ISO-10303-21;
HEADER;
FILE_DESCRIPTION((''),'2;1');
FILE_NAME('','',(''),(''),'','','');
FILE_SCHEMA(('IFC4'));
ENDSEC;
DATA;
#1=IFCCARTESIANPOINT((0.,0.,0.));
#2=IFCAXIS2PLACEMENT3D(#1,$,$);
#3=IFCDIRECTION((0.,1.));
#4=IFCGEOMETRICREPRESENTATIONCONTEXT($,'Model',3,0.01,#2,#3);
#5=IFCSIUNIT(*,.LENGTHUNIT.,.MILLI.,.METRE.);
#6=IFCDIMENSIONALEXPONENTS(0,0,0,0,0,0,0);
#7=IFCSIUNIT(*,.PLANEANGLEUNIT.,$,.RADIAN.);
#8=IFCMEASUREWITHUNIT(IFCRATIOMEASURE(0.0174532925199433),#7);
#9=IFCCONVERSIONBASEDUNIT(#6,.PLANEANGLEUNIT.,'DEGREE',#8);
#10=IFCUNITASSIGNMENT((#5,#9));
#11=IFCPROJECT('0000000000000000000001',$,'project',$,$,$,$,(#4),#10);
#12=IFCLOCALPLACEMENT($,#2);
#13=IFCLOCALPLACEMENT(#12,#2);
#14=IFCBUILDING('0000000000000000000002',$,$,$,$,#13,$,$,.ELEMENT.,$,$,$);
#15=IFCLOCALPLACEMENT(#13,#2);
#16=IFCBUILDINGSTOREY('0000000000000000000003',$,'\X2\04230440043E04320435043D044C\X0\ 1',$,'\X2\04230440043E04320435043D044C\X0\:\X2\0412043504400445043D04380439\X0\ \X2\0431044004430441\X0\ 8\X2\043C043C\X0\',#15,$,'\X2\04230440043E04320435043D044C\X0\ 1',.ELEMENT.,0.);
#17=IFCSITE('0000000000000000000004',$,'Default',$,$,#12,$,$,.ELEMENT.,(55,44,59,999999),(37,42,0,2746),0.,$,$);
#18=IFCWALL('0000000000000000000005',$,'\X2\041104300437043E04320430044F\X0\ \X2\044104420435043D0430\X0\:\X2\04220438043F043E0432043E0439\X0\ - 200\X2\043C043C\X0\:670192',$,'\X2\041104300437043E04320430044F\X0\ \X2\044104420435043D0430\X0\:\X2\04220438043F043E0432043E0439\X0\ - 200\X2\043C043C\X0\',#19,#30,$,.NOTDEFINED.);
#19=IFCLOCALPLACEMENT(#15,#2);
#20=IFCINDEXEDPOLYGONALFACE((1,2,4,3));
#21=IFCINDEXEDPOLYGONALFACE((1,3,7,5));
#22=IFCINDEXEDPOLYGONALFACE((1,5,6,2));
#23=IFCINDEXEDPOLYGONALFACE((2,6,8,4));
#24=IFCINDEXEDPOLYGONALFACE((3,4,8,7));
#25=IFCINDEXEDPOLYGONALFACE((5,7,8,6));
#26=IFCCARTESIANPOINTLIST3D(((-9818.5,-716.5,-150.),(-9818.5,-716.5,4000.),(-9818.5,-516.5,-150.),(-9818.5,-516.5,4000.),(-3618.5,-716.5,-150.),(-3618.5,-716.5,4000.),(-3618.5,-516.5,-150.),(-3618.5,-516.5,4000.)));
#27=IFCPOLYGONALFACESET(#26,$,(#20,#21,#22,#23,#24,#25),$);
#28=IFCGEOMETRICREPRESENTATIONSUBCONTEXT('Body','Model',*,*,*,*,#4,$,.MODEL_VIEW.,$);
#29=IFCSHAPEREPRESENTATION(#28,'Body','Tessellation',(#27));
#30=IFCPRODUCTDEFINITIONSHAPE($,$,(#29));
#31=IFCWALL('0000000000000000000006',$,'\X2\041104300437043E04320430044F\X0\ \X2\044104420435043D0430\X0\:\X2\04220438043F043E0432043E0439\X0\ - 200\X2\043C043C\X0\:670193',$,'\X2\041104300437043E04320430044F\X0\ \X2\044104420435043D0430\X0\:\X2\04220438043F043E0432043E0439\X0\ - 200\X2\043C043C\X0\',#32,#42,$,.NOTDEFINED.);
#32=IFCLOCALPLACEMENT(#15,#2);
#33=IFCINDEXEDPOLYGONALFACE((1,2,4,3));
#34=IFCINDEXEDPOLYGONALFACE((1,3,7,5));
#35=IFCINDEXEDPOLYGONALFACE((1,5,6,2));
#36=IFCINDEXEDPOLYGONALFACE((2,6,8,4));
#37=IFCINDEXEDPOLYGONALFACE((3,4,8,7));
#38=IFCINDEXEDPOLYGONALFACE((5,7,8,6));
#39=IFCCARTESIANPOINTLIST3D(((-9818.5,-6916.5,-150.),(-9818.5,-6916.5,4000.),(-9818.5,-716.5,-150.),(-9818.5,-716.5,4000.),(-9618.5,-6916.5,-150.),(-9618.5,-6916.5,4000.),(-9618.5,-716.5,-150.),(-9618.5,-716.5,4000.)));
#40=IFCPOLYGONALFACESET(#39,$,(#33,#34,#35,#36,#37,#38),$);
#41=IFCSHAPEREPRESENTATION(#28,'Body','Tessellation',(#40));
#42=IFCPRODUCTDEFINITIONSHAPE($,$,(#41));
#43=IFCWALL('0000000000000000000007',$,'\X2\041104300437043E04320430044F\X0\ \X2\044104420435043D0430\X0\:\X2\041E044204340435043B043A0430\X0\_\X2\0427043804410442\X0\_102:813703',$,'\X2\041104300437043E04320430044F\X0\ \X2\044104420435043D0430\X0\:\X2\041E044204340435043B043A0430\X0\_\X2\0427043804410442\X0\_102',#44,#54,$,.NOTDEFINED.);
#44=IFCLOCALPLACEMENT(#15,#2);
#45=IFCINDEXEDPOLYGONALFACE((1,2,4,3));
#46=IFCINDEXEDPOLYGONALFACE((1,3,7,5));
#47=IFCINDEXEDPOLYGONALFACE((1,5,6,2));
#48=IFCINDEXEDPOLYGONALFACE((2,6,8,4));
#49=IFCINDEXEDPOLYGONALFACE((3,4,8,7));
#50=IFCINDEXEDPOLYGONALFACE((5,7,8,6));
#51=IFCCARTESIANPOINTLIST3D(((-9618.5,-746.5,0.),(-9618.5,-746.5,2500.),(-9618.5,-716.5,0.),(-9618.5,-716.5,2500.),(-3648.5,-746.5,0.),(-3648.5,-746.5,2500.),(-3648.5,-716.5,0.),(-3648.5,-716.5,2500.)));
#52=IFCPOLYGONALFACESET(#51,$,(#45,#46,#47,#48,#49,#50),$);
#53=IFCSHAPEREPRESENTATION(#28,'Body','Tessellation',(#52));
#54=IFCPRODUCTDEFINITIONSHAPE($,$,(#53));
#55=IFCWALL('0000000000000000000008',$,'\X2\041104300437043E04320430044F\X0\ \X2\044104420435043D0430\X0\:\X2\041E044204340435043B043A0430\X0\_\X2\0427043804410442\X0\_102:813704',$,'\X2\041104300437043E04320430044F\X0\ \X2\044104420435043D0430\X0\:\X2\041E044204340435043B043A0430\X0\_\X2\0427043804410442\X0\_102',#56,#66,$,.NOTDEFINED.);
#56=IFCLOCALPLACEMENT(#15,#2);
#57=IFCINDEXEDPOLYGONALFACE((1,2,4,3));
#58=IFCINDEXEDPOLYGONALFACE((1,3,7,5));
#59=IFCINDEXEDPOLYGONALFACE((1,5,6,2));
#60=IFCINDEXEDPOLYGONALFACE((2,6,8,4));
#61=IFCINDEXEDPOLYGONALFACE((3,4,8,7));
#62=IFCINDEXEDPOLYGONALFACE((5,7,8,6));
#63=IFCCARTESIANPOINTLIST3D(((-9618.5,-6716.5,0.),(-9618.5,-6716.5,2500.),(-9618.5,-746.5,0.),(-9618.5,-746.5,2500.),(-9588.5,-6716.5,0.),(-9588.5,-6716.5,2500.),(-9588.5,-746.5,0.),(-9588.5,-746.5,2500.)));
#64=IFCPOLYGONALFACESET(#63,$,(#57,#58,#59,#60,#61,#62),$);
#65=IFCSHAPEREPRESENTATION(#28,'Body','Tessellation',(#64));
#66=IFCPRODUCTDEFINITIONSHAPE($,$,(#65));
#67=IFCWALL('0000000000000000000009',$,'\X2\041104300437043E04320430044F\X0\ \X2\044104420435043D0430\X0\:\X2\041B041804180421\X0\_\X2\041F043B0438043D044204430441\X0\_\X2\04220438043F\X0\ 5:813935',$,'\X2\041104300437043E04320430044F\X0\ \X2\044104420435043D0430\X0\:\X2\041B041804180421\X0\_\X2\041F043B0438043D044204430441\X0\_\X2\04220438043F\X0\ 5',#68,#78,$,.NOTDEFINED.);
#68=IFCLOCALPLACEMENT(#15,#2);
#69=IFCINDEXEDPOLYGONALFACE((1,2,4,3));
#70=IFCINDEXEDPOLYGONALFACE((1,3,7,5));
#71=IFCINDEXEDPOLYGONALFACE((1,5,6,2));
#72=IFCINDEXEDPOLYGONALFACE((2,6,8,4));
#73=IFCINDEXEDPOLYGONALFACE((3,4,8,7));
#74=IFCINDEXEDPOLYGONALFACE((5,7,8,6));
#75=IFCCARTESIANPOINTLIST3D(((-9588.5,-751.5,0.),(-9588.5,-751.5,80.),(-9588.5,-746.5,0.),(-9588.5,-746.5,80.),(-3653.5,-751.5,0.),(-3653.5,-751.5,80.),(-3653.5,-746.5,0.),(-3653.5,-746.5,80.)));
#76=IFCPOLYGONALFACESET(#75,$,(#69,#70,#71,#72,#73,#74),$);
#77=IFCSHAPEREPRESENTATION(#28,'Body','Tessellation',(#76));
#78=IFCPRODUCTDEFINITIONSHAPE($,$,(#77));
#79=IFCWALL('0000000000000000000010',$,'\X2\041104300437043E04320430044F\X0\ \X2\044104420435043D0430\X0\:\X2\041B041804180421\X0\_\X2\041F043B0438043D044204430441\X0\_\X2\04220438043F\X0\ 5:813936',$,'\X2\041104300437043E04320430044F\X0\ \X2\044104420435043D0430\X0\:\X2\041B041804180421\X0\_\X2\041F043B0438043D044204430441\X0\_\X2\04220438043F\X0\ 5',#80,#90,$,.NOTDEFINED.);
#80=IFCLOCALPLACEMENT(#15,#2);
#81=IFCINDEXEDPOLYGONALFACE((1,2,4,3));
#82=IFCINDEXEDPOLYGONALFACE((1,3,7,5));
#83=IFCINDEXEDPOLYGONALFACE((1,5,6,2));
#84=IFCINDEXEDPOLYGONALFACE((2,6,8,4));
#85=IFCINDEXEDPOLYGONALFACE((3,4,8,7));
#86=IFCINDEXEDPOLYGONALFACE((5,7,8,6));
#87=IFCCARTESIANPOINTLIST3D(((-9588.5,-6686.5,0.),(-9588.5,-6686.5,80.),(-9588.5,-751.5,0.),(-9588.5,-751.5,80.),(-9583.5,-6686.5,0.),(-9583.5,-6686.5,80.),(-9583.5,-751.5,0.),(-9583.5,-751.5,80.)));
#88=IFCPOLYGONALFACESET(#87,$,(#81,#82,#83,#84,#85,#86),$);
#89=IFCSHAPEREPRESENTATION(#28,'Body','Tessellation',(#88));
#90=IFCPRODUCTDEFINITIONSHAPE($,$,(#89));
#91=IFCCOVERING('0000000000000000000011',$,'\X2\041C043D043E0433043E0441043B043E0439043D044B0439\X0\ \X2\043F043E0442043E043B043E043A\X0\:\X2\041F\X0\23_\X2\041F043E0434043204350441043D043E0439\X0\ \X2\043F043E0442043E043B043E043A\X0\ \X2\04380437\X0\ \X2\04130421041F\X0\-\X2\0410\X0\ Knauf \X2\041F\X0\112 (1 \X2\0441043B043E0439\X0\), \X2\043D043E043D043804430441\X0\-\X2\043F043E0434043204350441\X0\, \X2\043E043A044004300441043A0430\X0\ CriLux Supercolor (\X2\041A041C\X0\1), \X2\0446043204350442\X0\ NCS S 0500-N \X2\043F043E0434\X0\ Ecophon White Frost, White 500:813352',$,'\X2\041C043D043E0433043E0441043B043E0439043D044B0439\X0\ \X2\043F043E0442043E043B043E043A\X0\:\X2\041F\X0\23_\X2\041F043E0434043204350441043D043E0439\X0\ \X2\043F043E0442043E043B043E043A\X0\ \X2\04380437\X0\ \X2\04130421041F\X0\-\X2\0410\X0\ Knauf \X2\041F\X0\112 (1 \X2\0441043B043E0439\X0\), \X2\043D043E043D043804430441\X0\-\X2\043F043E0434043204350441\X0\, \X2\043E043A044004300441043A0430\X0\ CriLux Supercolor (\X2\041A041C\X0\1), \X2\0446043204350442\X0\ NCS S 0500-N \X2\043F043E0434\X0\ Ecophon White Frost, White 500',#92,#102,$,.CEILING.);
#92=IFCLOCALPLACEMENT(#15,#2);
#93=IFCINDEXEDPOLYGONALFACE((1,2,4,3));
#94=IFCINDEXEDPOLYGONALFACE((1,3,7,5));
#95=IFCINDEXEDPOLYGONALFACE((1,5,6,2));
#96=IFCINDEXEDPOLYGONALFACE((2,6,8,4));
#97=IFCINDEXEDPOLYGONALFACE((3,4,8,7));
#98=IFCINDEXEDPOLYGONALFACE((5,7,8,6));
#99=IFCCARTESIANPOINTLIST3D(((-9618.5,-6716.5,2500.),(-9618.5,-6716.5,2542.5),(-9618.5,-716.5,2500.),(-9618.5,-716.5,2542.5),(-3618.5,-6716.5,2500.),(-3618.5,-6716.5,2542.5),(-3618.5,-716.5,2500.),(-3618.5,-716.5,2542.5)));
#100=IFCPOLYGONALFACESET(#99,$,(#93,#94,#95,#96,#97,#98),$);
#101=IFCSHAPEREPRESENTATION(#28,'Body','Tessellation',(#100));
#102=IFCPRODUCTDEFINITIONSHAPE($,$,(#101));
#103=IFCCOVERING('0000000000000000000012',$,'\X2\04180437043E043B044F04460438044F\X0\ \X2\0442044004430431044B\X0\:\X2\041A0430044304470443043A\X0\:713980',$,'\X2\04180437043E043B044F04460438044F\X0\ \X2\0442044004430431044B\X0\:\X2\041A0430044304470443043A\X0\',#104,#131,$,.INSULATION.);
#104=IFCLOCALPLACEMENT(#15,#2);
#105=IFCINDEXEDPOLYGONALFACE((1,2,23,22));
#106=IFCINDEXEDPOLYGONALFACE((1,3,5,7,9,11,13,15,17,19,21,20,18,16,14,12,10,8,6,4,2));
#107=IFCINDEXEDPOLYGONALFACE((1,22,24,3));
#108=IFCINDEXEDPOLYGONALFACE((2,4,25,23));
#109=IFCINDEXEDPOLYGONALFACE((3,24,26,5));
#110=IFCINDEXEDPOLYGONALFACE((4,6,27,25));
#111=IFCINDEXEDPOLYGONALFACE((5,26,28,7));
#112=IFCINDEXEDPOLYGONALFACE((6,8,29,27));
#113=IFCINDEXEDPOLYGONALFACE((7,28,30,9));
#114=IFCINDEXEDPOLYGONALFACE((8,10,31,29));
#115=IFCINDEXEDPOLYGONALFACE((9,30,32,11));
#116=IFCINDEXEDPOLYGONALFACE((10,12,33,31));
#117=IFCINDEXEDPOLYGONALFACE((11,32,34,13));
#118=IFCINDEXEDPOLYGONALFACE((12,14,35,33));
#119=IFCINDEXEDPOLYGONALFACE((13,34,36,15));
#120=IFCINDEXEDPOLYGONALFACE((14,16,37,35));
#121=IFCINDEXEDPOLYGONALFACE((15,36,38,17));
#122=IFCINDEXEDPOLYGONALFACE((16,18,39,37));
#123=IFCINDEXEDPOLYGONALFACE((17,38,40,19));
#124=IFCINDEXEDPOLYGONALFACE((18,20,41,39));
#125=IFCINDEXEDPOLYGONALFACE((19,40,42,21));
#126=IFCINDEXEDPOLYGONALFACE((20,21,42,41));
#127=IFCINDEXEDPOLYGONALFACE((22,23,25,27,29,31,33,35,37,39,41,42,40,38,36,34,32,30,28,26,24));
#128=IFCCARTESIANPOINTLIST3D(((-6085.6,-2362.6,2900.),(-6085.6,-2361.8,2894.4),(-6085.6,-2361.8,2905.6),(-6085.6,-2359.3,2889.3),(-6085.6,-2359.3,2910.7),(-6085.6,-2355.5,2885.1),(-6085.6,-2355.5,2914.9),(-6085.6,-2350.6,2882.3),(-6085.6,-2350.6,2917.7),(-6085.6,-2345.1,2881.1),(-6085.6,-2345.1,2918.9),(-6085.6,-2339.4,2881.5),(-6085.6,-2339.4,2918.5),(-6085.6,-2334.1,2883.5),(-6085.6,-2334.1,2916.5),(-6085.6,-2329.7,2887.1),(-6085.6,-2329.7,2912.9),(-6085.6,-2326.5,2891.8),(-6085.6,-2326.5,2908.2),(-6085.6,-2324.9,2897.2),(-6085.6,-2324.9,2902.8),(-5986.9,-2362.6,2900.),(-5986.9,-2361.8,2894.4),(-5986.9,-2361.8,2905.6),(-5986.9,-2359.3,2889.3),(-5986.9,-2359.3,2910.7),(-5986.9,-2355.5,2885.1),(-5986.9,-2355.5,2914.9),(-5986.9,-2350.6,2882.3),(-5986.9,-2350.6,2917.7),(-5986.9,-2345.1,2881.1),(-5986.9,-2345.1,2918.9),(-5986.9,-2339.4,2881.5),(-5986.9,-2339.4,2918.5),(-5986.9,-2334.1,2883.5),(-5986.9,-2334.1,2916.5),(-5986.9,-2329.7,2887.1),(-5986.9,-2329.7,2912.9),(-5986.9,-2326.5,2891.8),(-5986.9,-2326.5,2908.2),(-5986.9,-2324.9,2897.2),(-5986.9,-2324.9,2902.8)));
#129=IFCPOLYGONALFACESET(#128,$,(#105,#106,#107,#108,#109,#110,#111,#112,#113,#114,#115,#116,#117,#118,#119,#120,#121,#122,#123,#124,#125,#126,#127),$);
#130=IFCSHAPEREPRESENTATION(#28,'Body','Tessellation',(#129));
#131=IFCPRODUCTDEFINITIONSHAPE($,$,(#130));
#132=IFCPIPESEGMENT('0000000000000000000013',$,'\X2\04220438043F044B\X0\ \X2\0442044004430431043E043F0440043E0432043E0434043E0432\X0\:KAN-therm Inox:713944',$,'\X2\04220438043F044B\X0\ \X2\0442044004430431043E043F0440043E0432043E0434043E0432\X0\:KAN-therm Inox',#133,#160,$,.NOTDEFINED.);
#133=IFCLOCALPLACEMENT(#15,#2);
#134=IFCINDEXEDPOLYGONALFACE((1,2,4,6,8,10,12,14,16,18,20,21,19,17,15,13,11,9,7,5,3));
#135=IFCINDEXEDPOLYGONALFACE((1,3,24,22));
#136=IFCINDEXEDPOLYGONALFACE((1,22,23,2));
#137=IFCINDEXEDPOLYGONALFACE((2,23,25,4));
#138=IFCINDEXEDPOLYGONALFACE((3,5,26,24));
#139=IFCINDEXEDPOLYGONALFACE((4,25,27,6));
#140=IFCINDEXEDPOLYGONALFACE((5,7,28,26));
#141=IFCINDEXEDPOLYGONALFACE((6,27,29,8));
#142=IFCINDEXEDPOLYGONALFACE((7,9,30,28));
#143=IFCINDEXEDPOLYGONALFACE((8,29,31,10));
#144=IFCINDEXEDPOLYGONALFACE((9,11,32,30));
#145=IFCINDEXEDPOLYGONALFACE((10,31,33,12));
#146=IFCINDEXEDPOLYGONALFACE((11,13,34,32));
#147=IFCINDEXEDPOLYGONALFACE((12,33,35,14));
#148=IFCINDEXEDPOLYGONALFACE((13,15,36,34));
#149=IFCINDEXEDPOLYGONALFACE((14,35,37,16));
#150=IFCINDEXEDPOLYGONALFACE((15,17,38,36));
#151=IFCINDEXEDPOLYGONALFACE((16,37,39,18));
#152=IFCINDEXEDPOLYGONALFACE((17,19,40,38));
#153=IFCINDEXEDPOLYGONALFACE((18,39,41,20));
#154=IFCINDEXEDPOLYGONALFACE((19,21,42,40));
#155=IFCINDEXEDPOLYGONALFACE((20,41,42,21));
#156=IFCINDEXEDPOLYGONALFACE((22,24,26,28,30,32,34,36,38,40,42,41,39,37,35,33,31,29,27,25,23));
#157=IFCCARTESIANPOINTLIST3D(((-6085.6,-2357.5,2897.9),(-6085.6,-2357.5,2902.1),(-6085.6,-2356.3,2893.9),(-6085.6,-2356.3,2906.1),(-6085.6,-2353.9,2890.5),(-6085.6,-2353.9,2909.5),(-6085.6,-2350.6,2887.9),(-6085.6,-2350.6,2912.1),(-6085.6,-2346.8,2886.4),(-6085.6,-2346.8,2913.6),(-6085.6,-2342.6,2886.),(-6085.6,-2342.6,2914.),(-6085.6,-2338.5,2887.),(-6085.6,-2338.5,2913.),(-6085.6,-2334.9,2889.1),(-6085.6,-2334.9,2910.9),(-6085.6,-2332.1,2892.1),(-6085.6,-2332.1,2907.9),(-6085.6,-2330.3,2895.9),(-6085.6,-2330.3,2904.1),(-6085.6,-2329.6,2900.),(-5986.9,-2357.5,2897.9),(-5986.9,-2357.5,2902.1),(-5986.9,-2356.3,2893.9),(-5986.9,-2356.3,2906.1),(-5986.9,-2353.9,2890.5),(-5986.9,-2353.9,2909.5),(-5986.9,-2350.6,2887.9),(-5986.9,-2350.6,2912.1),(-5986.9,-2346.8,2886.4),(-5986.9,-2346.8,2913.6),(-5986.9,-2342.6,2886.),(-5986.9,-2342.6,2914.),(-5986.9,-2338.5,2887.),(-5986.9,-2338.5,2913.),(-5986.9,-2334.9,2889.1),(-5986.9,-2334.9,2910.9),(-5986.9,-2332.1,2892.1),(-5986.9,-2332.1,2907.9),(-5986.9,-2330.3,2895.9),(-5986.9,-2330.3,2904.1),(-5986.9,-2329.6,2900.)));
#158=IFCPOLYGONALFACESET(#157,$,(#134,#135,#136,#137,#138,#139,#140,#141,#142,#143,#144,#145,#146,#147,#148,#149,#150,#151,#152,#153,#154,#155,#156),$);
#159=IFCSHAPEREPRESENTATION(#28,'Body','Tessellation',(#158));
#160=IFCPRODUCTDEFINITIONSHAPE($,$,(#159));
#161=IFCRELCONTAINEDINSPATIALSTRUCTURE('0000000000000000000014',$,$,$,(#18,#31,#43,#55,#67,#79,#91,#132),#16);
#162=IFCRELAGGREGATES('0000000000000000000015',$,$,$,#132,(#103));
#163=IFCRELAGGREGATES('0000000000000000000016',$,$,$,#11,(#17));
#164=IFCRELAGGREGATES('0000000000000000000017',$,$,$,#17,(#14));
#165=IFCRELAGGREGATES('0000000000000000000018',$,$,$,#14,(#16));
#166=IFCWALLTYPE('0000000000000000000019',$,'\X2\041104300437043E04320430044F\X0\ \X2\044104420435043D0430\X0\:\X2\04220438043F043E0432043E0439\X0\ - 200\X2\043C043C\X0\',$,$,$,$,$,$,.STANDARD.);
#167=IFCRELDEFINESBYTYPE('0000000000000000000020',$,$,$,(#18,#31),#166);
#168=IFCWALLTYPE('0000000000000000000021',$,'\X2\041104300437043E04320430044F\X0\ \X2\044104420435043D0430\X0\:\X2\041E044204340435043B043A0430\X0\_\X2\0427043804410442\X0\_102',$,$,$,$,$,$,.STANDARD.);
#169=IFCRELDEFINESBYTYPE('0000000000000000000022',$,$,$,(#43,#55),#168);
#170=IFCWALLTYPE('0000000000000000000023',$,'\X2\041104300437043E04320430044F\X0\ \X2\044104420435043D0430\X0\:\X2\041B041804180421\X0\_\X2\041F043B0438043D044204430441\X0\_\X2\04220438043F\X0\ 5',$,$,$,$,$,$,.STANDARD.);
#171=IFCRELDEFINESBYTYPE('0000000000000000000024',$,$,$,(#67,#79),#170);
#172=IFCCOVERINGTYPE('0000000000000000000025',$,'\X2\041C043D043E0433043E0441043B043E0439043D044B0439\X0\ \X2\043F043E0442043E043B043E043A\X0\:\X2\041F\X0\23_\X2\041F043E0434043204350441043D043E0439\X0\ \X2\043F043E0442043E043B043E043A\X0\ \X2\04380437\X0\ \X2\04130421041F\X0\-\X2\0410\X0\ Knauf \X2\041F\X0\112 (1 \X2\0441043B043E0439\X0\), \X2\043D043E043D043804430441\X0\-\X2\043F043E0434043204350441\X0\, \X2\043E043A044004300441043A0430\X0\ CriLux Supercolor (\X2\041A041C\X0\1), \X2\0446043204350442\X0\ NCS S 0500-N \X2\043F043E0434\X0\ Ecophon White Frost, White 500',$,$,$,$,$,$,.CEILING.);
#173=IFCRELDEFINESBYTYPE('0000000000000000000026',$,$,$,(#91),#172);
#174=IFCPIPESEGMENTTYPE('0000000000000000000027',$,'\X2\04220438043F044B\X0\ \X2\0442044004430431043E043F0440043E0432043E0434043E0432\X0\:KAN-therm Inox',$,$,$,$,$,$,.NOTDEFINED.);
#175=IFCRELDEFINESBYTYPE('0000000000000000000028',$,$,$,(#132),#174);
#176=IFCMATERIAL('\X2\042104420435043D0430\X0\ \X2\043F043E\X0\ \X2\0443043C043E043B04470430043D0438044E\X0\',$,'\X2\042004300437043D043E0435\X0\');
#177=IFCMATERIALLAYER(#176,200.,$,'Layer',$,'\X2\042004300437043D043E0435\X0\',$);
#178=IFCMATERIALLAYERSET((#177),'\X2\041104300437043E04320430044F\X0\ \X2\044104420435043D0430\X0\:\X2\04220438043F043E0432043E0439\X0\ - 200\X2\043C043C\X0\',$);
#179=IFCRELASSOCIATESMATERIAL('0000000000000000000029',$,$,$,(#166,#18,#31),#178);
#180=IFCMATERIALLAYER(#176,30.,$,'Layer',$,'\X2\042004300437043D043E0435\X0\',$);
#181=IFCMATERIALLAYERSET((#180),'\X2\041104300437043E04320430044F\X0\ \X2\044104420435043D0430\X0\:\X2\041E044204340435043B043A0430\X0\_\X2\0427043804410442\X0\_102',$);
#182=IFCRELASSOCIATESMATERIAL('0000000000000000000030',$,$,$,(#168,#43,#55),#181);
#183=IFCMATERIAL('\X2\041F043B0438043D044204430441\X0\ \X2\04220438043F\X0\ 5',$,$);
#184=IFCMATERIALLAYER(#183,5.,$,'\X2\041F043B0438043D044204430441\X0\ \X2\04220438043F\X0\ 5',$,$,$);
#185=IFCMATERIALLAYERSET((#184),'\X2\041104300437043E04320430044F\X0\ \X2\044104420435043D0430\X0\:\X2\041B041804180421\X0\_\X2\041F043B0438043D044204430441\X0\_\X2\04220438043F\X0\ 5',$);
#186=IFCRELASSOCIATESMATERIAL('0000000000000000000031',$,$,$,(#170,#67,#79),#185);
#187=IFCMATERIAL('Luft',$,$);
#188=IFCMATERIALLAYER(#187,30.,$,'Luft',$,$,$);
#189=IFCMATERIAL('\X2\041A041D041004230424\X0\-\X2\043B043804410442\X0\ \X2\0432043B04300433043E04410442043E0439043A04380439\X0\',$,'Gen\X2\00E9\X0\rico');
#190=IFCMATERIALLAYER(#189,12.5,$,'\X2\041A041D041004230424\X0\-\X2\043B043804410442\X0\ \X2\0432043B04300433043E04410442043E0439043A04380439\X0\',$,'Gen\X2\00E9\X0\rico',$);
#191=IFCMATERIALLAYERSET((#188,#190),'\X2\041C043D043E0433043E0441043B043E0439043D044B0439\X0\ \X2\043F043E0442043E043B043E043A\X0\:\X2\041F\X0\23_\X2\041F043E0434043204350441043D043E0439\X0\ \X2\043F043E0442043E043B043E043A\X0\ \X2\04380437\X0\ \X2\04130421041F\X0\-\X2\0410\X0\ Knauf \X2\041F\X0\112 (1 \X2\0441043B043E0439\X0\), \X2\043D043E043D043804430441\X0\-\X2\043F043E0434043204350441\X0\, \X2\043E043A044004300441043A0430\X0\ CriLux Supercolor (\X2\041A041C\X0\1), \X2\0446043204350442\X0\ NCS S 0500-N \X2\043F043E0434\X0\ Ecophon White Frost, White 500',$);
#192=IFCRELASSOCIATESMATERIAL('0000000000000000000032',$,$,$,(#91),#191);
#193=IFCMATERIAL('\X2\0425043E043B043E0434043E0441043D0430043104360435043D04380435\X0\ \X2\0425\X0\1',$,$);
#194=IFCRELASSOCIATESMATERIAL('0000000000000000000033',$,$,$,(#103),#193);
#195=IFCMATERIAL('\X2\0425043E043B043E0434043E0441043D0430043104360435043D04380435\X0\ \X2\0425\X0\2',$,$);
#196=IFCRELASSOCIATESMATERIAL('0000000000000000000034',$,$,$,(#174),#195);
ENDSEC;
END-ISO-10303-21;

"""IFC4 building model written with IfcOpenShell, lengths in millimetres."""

from ifc_helpers import new_model, entity, si_unit, converted_unit, direction, frame, frame_2d, origin, origin_2d_with_axis, place, context, subcontext, project, spatial, rectangle, circle, extrude, material, layer, layer_set, layer_usage, type_object, element, aggregate, save


model = new_model("IFC4")

# Units and contexts
model_context = context("Model", 3, precision=0.01, world=origin(), true_north=direction((0.0, 1.0)))
body_context = subcontext(model_context, "Body", "Model", "MODEL_VIEW")
ifc_project = project(units=[si_unit("LENGTHUNIT", "METRE", prefix="MILLI"), converted_unit("PLANEANGLEUNIT", "DEGREE", entity("IfcRatioMeasure", 0.0174532925199433), si_unit("PLANEANGLEUNIT", "RADIAN"), dimensions=[0, 0, 0, 0, 0, 0, 0])], contexts=[model_context])

# Site, building, storey
site_placement = place(None, origin())
site = spatial("IfcSite", under=ifc_project, at=site_placement, Name="Default", CompositionType="ELEMENT", RefLatitude=(55, 44, 59, 999999), RefLongitude=(37, 42, 0, 2746), RefElevation=0.0)
building_placement = place(site_placement, origin())
building = spatial("IfcBuilding", under=site, at=building_placement, CompositionType="ELEMENT")
storey_placement = place(building_placement, origin())
storey = spatial("IfcBuildingStorey", under=building, at=storey_placement, Name="Уровень 1", ObjectType="Уровень:Верхний брус 8мм", LongName="Уровень 1", CompositionType="ELEMENT", Elevation=0.0)

# Walls
ifc_material_1 = material(Name="Стена по умолчанию", Category="Разное")
ifc_layer_1 = layer(ifc_material_1, 200.0, Name="Layer", Category="Разное")
ifc_layer_set_1 = layer_set([ifc_layer_1], Name="Базовая стена:Типовой - 200мм")
ifc_layer_usage_1 = layer_usage(ifc_layer_set_1, "AXIS2", "NEGATIVE", 100.0)
wall_type_1 = type_object("IfcWallType", Name="Базовая стена:Типовой - 200мм", PredefinedType="STANDARD", material=ifc_layer_set_1)
wall_1_placement = place(storey_placement, frame((-9818.5, -616.5, -150.0)))
element("IfcWall", 1, at=wall_1_placement, inside=storey, type_object=wall_type_1, material=ifc_layer_usage_1, Name="Базовая стена:Типовой - 200мм:670192", ObjectType="Базовая стена:Типовой - 200мм", PredefinedType="NOTDEFINED", context=body_context, shape_type="SweptSolid", body=[
    extrude(rectangle(XDim=6200.0, YDim=200.0, at=frame_2d((3100.0, 0.0), x_axis=(-1.0, 0.0))), origin(), (0.0, 0.0, 1.0), 4150.0),
])
ifc_layer_usage_2 = layer_usage(ifc_layer_set_1, "AXIS2", "NEGATIVE", 100.0)
wall_2_placement = place(storey_placement, frame((-9718.5, -6916.5, -150.0), z_axis=(0.0, 0.0, 1.0), x_axis=(0.0, 1.0, 0.0)))
element("IfcWall", 2, at=wall_2_placement, inside=storey, type_object=wall_type_1, material=ifc_layer_usage_2, Name="Базовая стена:Типовой - 200мм:670193", ObjectType="Базовая стена:Типовой - 200мм", PredefinedType="NOTDEFINED", context=body_context, shape_type="SweptSolid", body=[
    extrude(rectangle(XDim=6200.0, YDim=200.0, at=frame_2d((3100.0, 0.0), x_axis=(-1.0, 0.0))), origin(), (0.0, 0.0, 1.0), 4150.0),
])
ifc_layer_2 = layer(ifc_material_1, 30.0, Name="Layer", Category="Разное")
ifc_layer_set_2 = layer_set([ifc_layer_2], Name="Базовая стена:Отделка_Чист_102")
ifc_layer_usage_3 = layer_usage(ifc_layer_set_2, "AXIS2", "POSITIVE", -15.0)
wall_type_2 = type_object("IfcWallType", Name="Базовая стена:Отделка_Чист_102", PredefinedType="STANDARD", material=ifc_layer_set_2)
wall_3_placement = place(storey_placement, frame((-9618.5, -731.5, 0.0)))
element("IfcWall", 3, at=wall_3_placement, inside=storey, type_object=wall_type_2, material=ifc_layer_usage_3, Name="Базовая стена:Отделка_Чист_102:813703", ObjectType="Базовая стена:Отделка_Чист_102", PredefinedType="NOTDEFINED", context=body_context, shape_type="SweptSolid", body=[
    extrude(rectangle(XDim=5970.0, YDim=30.0, at=frame_2d((2985.0, 0.0), x_axis=(-1.0, 0.0))), origin(), (0.0, 0.0, 1.0), 2500.0),
])
ifc_layer_usage_4 = layer_usage(ifc_layer_set_2, "AXIS2", "POSITIVE", -15.0)
wall_4_placement = place(storey_placement, frame((-9603.5, -6716.5, 0.0), z_axis=(0.0, 0.0, 1.0), x_axis=(0.0, 1.0, 0.0)))
element("IfcWall", 4, at=wall_4_placement, inside=storey, type_object=wall_type_2, material=ifc_layer_usage_4, Name="Базовая стена:Отделка_Чист_102:813704", ObjectType="Базовая стена:Отделка_Чист_102", PredefinedType="NOTDEFINED", context=body_context, shape_type="SweptSolid", body=[
    extrude(rectangle(XDim=5970.0, YDim=30.0, at=frame_2d((2985.0, 0.0), x_axis=(-1.0, 0.0))), origin(), (0.0, 0.0, 1.0), 2500.0),
])
ifc_material_2 = material(Name="Плинтус Тип 5")
ifc_layer_3 = layer(ifc_material_2, 5.0, Name="Плинтус Тип 5")
ifc_layer_set_3 = layer_set([ifc_layer_3], Name="Базовая стена:ЛИИС_Плинтус_Тип 5")
ifc_layer_usage_5 = layer_usage(ifc_layer_set_3, "AXIS2", "NEGATIVE", 2.5)
wall_type_3 = type_object("IfcWallType", Name="Базовая стена:ЛИИС_Плинтус_Тип 5", PredefinedType="STANDARD", material=ifc_layer_set_3)
wall_5_placement = place(storey_placement, frame((-9588.5, -749.0, 0.0)))
element("IfcWall", 5, at=wall_5_placement, inside=storey, type_object=wall_type_3, material=ifc_layer_usage_5, Name="Базовая стена:ЛИИС_Плинтус_Тип 5:813935", ObjectType="Базовая стена:ЛИИС_Плинтус_Тип 5", PredefinedType="NOTDEFINED", context=body_context, shape_type="SweptSolid", body=[
    extrude(rectangle(XDim=5935.0, YDim=5.0, at=frame_2d((2967.5, 0.0), x_axis=(-1.0, 0.0))), origin(), (0.0, 0.0, 1.0), 80.0),
])
ifc_layer_usage_6 = layer_usage(ifc_layer_set_3, "AXIS2", "NEGATIVE", 2.5)
wall_6_placement = place(storey_placement, frame((-9586.0, -6686.5, 0.0), z_axis=(0.0, 0.0, 1.0), x_axis=(0.0, 1.0, 0.0)))
element("IfcWall", 6, at=wall_6_placement, inside=storey, type_object=wall_type_3, material=ifc_layer_usage_6, Name="Базовая стена:ЛИИС_Плинтус_Тип 5:813936", ObjectType="Базовая стена:ЛИИС_Плинтус_Тип 5", PredefinedType="NOTDEFINED", context=body_context, shape_type="SweptSolid", body=[
    extrude(rectangle(XDim=5935.0, YDim=5.0, at=frame_2d((2967.5, 0.0), x_axis=(-1.0, 0.0))), origin(), (0.0, 0.0, 1.0), 80.0),
])

# Coverings
ifc_material_3 = material(Name="Luft")
ifc_layer_4 = layer(ifc_material_3, 30.0, Name="Luft")
ifc_material_4 = material(Name="КНАУФ-лист влагостойкий", Category="Genérico")
ifc_layer_5 = layer(ifc_material_4, 12.5, Name="КНАУФ-лист влагостойкий", Category="Genérico")
ifc_layer_set_4 = layer_set([ifc_layer_4, ifc_layer_5], Name="Многослойный потолок:П23_Подвесной потолок из ГСП-А Knauf П112 (1 слой), нониус-подвес, окраска CriLux Supercolor (КМ1), цвет NCS S 0500-N под Ecophon White Frost, White 500")
ifc_layer_usage_7 = layer_usage(ifc_layer_set_4, "AXIS3", "POSITIVE", 0.0)
covering_type = type_object("IfcCoveringType", Name="Многослойный потолок:П23_Подвесной потолок из ГСП-А Knauf П112 (1 слой), нониус-подвес, окраска CriLux Supercolor (КМ1), цвет NCS S 0500-N под Ecophon White Frost, White 500", PredefinedType="CEILING")
covering_1_placement = place(storey_placement, frame((-9618.5, -6716.5, 2500.0)))
element("IfcCovering", 7, at=covering_1_placement, inside=storey, type_object=covering_type, material=ifc_layer_usage_7, Name="Многослойный потолок:П23_Подвесной потолок из ГСП-А Knauf П112 (1 слой), нониус-подвес, окраска CriLux Supercolor (КМ1), цвет NCS S 0500-N под Ecophon White Frost, White 500:813352", ObjectType="Многослойный потолок:П23_Подвесной потолок из ГСП-А Knauf П112 (1 слой), нониус-подвес, окраска CriLux Supercolor (КМ1), цвет NCS S 0500-N под Ecophon White Frost, White 500", PredefinedType="CEILING", context=body_context, shape_type="SweptSolid", body=[
    extrude(rectangle(XDim=6000.0, YDim=6000.0, at=origin_2d_with_axis()), frame((3000.0, 3000.0, 0.0), z_axis=(0.0, 0.0, 1.0), x_axis=(0.0, -1.0, 0.0)), (0.0, 0.0, 1.0), 42.5),
])
ifc_material_5 = material(Name="Холодоснабжение Х1")
covering_2_placement = place(storey_placement, frame((-6085.6, -2364.2, 2879.4)))
covering_2 = element("IfcCovering", 8, at=covering_2_placement, material=ifc_material_5, Name="Изоляция трубы:Каучук:713980", ObjectType="Изоляция трубы:Каучук", PredefinedType="INSULATION", context=body_context, shape_type="SweptSolid", body=[
    extrude(circle(Radius=19.0, at=frame_2d((0.0, 0.0), x_axis=(1.0, 0.0))), frame((0.0, 20.6, 20.6), z_axis=(1.0, 0.0, 0.0), x_axis=(0.0, -1.0, 0.0)), (0.0, 0.0, 1.0), 98.6),
])
ifc_material_6 = material(Name="Холодоснабжение Х2")

# Pipe segment
pipe_segment_type_1 = type_object("IfcPipeSegmentType", Name="Типы трубопроводов:KAN-therm Inox", PredefinedType="NOTDEFINED", material=ifc_material_6)
pipe_segment_1_placement = place(storey_placement, frame((-6085.6, -2359.2, 2884.4)))
pipe_segment_1 = element("IfcPipeSegment", 9, at=pipe_segment_1_placement, inside=storey, type_object=pipe_segment_type_1, Name="Типы трубопроводов:KAN-therm Inox:713944", ObjectType="Типы трубопроводов:KAN-therm Inox", PredefinedType="NOTDEFINED", context=body_context, shape_type="SweptSolid", body=[
    extrude(circle(Radius=14.0, at=frame_2d((0.0, 0.0), x_axis=(1.0, 0.0))), frame((0.0, 15.6, 15.6), z_axis=(1.0, 0.0, 0.0), x_axis=(0.0, 1.0, 0.0)), (0.0, 0.0, 1.0), 98.6),
])
aggregate(pipe_segment_1, [covering_2])

save(model, "model.ifc")
